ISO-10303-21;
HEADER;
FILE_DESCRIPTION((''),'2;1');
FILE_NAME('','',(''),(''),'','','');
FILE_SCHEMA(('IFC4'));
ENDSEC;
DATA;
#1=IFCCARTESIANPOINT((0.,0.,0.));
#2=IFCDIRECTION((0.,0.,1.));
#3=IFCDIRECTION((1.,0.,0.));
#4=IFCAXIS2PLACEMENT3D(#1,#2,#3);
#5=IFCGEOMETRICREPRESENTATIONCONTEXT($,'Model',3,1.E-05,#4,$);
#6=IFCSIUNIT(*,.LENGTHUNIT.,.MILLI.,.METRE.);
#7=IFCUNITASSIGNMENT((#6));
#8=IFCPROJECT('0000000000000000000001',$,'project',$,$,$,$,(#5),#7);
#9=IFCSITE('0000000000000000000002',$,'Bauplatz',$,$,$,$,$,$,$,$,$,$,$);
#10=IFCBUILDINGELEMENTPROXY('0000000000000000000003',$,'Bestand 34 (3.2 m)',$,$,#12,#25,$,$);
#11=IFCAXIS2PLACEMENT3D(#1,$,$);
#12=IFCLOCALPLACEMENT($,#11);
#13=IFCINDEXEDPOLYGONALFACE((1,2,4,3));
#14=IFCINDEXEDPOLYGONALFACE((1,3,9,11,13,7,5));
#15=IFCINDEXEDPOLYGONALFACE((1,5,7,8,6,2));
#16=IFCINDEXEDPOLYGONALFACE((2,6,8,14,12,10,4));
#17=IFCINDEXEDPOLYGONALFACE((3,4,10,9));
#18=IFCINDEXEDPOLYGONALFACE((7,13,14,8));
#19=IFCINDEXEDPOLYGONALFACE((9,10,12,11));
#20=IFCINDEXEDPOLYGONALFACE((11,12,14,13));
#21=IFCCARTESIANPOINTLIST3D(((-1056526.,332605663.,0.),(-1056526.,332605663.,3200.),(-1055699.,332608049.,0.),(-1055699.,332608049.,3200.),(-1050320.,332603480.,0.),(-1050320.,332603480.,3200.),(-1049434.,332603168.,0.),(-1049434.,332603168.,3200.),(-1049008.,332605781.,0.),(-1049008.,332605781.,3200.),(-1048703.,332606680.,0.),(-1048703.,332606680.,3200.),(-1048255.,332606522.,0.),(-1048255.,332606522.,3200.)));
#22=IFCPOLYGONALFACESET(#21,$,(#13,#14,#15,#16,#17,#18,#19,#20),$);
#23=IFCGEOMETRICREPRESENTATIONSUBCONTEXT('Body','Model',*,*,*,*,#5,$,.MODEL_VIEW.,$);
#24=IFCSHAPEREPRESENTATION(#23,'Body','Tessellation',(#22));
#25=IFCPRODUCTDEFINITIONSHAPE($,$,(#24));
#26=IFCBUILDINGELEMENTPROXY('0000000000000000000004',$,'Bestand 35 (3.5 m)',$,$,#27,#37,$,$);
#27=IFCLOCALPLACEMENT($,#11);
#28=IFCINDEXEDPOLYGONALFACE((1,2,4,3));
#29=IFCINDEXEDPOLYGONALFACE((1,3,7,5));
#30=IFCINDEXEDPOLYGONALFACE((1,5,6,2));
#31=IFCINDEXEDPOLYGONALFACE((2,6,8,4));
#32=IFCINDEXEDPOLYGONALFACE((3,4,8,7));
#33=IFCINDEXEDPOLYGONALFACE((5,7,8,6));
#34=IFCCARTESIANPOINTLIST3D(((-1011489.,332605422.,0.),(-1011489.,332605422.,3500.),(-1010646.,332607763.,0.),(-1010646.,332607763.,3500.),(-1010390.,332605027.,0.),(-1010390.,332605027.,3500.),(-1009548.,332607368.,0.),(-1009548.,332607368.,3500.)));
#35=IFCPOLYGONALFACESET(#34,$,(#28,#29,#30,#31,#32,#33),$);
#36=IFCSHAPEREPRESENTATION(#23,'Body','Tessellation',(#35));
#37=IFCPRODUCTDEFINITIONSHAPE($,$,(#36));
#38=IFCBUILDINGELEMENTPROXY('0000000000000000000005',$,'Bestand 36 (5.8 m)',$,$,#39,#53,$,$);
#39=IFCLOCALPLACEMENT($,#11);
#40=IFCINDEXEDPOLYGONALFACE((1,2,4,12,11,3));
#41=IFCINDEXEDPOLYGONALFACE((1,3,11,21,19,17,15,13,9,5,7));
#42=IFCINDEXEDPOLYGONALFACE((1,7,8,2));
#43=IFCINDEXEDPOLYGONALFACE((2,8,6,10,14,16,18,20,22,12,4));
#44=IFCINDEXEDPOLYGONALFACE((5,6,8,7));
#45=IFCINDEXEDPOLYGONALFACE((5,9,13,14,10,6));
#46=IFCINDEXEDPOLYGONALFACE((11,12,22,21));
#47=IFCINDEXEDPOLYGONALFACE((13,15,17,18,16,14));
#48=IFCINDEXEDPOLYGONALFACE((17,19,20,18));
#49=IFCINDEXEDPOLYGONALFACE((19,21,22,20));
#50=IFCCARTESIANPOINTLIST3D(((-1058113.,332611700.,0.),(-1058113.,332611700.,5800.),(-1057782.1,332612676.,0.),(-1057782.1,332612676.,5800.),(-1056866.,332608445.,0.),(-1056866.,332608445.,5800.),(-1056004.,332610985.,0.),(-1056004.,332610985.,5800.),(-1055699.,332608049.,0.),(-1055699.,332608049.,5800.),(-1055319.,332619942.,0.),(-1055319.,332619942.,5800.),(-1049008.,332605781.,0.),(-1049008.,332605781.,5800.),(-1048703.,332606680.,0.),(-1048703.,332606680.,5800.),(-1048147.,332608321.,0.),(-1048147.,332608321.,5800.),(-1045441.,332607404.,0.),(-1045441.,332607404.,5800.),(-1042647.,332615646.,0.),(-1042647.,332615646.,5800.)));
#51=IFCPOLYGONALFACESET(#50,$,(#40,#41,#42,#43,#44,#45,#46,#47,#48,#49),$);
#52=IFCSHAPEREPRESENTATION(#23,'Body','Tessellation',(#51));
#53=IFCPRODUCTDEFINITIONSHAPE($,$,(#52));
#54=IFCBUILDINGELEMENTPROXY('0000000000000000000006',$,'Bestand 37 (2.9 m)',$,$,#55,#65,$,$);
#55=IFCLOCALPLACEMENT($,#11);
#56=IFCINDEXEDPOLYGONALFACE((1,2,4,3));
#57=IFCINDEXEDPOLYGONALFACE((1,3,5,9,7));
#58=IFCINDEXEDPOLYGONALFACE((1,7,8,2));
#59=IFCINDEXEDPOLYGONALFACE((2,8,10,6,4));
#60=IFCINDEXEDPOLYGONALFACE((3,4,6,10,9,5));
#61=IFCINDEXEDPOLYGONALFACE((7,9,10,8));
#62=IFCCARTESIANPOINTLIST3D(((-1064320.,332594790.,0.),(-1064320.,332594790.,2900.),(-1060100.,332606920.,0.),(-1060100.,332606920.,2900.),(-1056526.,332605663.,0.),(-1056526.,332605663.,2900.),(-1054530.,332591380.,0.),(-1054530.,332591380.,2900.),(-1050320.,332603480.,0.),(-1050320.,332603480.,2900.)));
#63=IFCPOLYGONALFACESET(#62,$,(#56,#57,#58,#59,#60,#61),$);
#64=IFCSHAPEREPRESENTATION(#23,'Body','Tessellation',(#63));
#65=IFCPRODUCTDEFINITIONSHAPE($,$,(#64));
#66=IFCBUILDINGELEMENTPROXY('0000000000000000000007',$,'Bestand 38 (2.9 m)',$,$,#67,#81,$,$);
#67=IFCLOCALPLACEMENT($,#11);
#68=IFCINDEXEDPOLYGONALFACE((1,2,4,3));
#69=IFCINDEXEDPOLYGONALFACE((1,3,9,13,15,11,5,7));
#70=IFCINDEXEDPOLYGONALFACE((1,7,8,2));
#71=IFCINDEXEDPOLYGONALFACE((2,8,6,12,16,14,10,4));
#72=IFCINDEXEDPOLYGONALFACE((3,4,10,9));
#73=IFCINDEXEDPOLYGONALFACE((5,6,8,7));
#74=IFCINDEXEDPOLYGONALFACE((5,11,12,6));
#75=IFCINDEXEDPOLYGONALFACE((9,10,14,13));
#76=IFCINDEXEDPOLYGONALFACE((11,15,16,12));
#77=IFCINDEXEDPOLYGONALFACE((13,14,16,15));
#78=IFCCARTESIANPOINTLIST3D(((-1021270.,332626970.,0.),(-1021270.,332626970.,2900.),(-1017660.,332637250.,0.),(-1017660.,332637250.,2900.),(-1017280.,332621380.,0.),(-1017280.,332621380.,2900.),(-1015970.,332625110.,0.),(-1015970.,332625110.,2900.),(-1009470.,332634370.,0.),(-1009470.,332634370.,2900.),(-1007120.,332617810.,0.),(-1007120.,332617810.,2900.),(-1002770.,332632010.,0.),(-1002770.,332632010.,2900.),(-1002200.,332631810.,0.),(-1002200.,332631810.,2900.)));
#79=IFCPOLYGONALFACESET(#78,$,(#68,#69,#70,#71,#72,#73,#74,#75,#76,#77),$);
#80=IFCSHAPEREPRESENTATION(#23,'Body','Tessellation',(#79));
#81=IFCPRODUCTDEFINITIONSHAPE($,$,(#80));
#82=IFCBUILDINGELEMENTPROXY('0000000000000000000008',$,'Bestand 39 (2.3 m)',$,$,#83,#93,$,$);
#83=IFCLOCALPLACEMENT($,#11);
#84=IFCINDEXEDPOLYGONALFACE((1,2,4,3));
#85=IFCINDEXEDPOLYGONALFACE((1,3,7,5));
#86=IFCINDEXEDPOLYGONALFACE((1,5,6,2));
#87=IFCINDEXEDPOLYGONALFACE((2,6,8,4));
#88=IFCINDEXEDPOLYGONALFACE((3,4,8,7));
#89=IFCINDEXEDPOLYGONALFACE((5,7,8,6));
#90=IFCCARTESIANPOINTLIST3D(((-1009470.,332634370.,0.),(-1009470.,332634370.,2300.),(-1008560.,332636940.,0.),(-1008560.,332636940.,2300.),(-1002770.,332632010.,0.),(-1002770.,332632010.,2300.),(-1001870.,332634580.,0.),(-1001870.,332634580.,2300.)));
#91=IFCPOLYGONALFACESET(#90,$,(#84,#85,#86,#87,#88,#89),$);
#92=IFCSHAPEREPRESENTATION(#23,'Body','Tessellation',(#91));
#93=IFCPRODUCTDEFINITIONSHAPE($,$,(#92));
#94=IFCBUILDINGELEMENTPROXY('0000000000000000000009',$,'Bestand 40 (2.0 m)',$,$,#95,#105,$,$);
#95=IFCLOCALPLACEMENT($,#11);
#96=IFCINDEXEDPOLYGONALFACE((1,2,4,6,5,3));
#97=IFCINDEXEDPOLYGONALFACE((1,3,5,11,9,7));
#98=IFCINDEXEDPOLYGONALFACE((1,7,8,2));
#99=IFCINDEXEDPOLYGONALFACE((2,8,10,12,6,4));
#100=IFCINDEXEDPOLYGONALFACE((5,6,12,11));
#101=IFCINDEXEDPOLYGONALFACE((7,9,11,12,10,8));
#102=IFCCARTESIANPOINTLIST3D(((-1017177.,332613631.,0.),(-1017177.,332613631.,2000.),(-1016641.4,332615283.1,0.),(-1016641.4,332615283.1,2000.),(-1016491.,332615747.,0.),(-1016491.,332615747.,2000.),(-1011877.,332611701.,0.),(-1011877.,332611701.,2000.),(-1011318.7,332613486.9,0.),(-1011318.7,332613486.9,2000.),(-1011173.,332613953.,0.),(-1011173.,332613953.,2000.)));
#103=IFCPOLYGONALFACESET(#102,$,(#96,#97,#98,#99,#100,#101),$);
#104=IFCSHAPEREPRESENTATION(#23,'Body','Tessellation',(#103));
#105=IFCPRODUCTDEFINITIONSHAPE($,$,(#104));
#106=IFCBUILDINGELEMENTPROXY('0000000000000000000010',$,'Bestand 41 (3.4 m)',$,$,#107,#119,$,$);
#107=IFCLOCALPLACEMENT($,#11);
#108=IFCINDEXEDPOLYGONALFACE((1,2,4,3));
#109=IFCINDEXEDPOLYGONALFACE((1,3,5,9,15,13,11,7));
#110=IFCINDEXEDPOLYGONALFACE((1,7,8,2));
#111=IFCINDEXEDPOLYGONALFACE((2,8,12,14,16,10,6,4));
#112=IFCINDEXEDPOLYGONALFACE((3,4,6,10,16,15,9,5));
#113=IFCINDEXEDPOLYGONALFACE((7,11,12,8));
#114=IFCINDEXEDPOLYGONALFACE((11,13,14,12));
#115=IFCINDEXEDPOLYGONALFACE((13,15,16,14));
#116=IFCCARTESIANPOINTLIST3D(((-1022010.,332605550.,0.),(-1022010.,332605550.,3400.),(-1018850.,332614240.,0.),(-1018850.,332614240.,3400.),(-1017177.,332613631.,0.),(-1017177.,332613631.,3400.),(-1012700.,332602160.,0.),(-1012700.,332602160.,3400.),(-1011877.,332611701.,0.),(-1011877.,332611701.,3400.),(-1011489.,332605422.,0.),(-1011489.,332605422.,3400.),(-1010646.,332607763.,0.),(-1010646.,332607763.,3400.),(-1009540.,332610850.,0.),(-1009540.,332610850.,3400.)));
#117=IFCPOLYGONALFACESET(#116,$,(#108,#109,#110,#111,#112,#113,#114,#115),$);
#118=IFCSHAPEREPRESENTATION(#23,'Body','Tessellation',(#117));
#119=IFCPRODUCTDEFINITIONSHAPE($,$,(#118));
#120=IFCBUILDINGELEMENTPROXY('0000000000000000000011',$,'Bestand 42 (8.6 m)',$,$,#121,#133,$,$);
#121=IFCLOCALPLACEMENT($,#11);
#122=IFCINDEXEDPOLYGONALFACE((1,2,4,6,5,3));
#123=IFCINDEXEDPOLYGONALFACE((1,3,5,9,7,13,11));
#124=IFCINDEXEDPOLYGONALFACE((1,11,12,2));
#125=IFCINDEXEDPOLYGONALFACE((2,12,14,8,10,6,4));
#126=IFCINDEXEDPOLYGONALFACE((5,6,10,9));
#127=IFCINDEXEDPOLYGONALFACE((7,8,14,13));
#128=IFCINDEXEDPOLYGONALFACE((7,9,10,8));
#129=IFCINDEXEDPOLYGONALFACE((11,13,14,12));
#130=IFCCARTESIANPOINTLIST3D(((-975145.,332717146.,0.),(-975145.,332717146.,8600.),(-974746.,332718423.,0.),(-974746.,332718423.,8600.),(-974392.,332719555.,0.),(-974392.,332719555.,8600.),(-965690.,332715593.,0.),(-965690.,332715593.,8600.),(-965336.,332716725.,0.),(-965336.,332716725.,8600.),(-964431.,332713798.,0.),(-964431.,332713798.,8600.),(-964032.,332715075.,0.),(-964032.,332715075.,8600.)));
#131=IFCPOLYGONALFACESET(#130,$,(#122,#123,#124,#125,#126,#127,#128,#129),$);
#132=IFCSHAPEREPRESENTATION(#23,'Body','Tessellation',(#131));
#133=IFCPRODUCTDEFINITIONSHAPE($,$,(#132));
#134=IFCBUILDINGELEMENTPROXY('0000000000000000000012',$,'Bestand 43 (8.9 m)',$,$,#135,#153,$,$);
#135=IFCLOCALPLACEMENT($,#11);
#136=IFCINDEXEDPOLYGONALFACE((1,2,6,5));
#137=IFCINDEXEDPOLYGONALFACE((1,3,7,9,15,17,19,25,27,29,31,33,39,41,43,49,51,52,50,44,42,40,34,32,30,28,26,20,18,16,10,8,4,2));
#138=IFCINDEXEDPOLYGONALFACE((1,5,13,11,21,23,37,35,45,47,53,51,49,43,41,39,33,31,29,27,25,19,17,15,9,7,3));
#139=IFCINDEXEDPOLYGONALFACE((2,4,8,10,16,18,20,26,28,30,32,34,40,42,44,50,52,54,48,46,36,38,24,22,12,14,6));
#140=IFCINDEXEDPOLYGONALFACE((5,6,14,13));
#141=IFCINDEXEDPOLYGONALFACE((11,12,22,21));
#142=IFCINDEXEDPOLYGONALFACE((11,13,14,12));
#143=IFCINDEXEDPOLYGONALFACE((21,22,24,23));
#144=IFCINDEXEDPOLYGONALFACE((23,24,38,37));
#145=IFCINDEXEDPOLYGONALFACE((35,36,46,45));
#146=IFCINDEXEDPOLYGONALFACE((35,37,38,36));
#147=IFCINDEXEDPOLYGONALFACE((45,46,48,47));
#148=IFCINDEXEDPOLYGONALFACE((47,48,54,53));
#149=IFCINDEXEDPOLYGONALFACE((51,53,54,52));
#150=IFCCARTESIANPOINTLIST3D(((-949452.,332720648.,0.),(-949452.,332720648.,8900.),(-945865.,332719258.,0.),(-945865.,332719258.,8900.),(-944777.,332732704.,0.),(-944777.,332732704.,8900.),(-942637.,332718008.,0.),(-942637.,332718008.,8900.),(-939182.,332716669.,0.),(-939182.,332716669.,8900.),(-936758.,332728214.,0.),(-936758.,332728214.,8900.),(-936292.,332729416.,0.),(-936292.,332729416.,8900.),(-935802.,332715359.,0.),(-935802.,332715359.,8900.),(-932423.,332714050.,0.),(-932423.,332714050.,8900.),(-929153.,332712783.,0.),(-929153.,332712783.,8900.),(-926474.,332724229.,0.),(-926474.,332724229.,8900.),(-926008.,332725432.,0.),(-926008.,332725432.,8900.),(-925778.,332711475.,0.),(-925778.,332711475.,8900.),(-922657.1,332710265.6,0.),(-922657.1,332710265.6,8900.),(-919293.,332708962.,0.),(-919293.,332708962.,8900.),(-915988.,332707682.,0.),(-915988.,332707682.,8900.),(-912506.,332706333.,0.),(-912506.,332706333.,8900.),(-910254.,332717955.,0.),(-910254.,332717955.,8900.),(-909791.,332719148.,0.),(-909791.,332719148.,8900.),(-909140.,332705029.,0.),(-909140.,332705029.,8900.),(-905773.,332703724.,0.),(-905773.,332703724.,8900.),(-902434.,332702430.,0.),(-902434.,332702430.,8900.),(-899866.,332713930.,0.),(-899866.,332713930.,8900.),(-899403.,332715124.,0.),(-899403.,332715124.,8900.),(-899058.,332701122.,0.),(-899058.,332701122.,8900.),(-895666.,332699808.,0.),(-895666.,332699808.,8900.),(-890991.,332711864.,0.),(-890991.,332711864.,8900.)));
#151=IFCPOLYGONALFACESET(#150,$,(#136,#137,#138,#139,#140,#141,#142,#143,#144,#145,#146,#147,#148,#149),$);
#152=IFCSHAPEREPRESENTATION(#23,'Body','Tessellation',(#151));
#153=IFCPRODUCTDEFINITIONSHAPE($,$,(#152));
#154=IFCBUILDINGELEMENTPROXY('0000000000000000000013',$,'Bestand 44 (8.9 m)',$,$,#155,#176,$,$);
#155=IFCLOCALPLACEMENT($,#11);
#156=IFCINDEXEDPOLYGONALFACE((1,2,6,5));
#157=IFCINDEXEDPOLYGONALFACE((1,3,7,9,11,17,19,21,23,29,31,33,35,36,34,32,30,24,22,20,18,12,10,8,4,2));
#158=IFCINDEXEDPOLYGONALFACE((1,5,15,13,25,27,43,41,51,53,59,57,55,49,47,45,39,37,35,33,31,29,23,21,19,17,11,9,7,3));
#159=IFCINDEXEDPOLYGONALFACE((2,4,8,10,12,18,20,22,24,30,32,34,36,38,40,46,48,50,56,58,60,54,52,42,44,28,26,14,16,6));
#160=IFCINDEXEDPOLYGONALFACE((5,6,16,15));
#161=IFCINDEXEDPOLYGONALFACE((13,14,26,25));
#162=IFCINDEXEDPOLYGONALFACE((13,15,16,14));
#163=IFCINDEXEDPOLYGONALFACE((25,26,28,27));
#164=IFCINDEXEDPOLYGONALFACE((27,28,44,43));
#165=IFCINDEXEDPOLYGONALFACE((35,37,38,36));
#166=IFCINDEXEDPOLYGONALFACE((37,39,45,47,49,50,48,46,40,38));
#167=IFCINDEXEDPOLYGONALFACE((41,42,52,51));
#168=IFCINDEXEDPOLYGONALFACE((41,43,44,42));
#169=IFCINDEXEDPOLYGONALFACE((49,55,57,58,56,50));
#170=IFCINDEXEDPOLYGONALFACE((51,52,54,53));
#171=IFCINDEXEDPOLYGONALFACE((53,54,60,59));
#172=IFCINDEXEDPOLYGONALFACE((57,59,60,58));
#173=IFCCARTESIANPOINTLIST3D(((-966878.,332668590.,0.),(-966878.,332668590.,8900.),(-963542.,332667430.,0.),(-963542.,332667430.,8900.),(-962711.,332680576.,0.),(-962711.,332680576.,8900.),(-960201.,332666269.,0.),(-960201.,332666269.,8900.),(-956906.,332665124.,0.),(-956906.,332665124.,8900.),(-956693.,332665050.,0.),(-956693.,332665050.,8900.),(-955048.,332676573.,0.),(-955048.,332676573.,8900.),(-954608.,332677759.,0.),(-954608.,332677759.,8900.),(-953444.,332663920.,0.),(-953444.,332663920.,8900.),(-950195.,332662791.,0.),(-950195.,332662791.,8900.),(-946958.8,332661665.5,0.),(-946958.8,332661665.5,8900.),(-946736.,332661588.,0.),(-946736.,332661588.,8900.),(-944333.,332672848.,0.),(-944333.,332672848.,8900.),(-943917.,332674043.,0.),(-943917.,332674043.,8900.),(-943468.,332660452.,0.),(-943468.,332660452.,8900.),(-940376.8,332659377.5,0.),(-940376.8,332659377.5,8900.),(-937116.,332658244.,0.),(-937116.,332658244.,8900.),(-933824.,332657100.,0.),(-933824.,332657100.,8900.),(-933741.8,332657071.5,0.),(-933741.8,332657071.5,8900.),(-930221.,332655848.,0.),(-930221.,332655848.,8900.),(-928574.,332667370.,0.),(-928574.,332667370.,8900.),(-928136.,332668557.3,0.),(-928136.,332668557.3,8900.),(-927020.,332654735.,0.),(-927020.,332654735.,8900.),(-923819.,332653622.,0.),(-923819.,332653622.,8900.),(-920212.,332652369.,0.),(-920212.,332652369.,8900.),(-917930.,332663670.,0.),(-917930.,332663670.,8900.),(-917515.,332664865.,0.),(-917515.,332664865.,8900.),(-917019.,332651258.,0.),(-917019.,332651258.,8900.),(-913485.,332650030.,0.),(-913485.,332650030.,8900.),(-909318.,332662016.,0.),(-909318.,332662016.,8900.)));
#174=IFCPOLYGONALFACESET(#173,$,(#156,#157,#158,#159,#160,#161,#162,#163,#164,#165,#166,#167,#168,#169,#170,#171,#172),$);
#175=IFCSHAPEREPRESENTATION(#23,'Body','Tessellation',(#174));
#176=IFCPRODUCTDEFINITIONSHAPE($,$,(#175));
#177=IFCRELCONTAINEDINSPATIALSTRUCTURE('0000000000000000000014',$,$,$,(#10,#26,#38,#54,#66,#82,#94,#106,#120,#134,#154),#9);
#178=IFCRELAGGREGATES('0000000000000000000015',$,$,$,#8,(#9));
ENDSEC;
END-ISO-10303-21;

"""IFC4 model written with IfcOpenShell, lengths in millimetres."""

from ifc_helpers import new_model, si_unit, origin_with_axes, place, context, subcontext, project, spatial, indexed_curve, outline, extrude, element, save


model = new_model("IFC4")

# Units and contexts
model_context = context("Model", 3, precision=1e-05, world=origin_with_axes())
body_context = subcontext(model_context, "Body", "Model", "MODEL_VIEW")
ifc_project = project(units=[si_unit("LENGTHUNIT", "METRE", prefix="MILLI")], contexts=[model_context])

# Site
site = spatial("IfcSite", under=ifc_project, Name="Bauplatz")

# Building element proxies
proxy_1_placement = place(None, origin_with_axes())
element("IfcBuildingElementProxy", 1, at=proxy_1_placement, inside=site, Name="Bestand 34 (3.2 m)", context=body_context, shape_type="SweptSolid", body=[
    extrude(outline(indexed_curve([(-1049008.0, 332605781.0), (-1055699.0, 332608049.0), (-1056526.0, 332605663.0), (-1050320.0, 332603480.0), (-1049434.0, 332603168.0), (-1048255.0, 332606522.0), (-1048703.0, 332606680.0)])), None, (0.0, 0.0, 1.0), 3200.0),
])
proxy_2_placement = place(None, origin_with_axes())
element("IfcBuildingElementProxy", 2, at=proxy_2_placement, inside=site, Name="Bestand 35 (3.5 m)", context=body_context, shape_type="SweptSolid", body=[
    extrude(outline(indexed_curve([(-1009548.0, 332607368.0), (-1010646.0, 332607763.0), (-1011489.0, 332605422.0), (-1010390.0, 332605027.0)])), None, (0.0, 0.0, 1.0), 3500.0),
])
proxy_3_placement = place(None, origin_with_axes())
element("IfcBuildingElementProxy", 3, at=proxy_3_placement, inside=site, Name="Bestand 36 (5.8 m)", context=body_context, shape_type="SweptSolid", body=[
    extrude(outline(indexed_curve([(-1042647.0, 332615646.0), (-1055319.0, 332619942.0), (-1057782.1, 332612676.0), (-1058113.0, 332611700.0), (-1056004.0, 332610985.0), (-1056866.0, 332608445.0), (-1055699.0, 332608049.0), (-1049008.0, 332605781.0), (-1048703.0, 332606680.0), (-1048147.0, 332608321.0), (-1045441.0, 332607404.0)])), None, (0.0, 0.0, 1.0), 5800.0),
])
proxy_4_placement = place(None, origin_with_axes())
element("IfcBuildingElementProxy", 4, at=proxy_4_placement, inside=site, Name="Bestand 37 (2.9 m)", context=body_context, shape_type="SweptSolid", body=[
    extrude(outline(indexed_curve([(-1056526.0, 332605663.0), (-1060100.0, 332606920.0), (-1064320.0, 332594790.0), (-1054530.0, 332591380.0), (-1050320.0, 332603480.0)])), None, (0.0, 0.0, 1.0), 2900.0),
])
proxy_5_placement = place(None, origin_with_axes())
element("IfcBuildingElementProxy", 5, at=proxy_5_placement, inside=site, Name="Bestand 38 (2.9 m)", context=body_context, shape_type="SweptSolid", body=[
    extrude(outline(indexed_curve([(-1009470.0, 332634370.0), (-1017660.0, 332637250.0), (-1021270.0, 332626970.0), (-1015970.0, 332625110.0), (-1017280.0, 332621380.0), (-1007120.0, 332617810.0), (-1002200.0, 332631810.0), (-1002770.0, 332632010.0)])), None, (0.0, 0.0, 1.0), 2900.0),
])
proxy_6_placement = place(None, origin_with_axes())
element("IfcBuildingElementProxy", 6, at=proxy_6_placement, inside=site, Name="Bestand 39 (2.3 m)", context=body_context, shape_type="SweptSolid", body=[
    extrude(outline(indexed_curve([(-1001870.0, 332634580.0), (-1008560.0, 332636940.0), (-1009470.0, 332634370.0), (-1002770.0, 332632010.0)])), None, (0.0, 0.0, 1.0), 2300.0),
])
proxy_7_placement = place(None, origin_with_axes())
element("IfcBuildingElementProxy", 7, at=proxy_7_placement, inside=site, Name="Bestand 40 (2.0 m)", context=body_context, shape_type="SweptSolid", body=[
    extrude(outline(indexed_curve([(-1011173.0, 332613953.0), (-1016491.0, 332615747.0), (-1016641.4, 332615283.1), (-1017177.0, 332613631.0), (-1011877.0, 332611701.0), (-1011318.7, 332613486.9)])), None, (0.0, 0.0, 1.0), 2000.0),
])
proxy_8_placement = place(None, origin_with_axes())
element("IfcBuildingElementProxy", 8, at=proxy_8_placement, inside=site, Name="Bestand 41 (3.4 m)", context=body_context, shape_type="SweptSolid", body=[
    extrude(outline(indexed_curve([(-1017177.0, 332613631.0), (-1018850.0, 332614240.0), (-1022010.0, 332605550.0), (-1012700.0, 332602160.0), (-1011489.0, 332605422.0), (-1010646.0, 332607763.0), (-1009540.0, 332610850.0), (-1011877.0, 332611701.0)])), None, (0.0, 0.0, 1.0), 3400.0),
])
proxy_9_placement = place(None, origin_with_axes())
element("IfcBuildingElementProxy", 9, at=proxy_9_placement, inside=site, Name="Bestand 42 (8.6 m)", context=body_context, shape_type="SweptSolid", body=[
    extrude(outline(indexed_curve([(-965336.0, 332716725.0), (-974392.0, 332719555.0), (-974746.0, 332718423.0), (-975145.0, 332717146.0), (-964431.0, 332713798.0), (-964032.0, 332715075.0), (-965690.0, 332715593.0)])), None, (0.0, 0.0, 1.0), 8600.0),
])
proxy_10_placement = place(None, origin_with_axes())
element("IfcBuildingElementProxy", 10, at=proxy_10_placement, inside=site, Name="Bestand 43 (8.9 m)", context=body_context, shape_type="SweptSolid", body=[
    extrude(outline(indexed_curve([(-936292.0, 332729416.0), (-944777.0, 332732704.0), (-949452.0, 332720648.0), (-945865.0, 332719258.0), (-942637.0, 332718008.0), (-939182.0, 332716669.0), (-935802.0, 332715359.0), (-932423.0, 332714050.0), (-929153.0, 332712783.0), (-925778.0, 332711475.0), (-922657.1, 332710265.6), (-919293.0, 332708962.0), (-915988.0, 332707682.0), (-912506.0, 332706333.0), (-909140.0, 332705029.0), (-905773.0, 332703724.0), (-902434.0, 332702430.0), (-899058.0, 332701122.0), (-895666.0, 332699808.0), (-890991.0, 332711864.0), (-899403.0, 332715124.0), (-899866.0, 332713930.0), (-910254.0, 332717955.0), (-909791.0, 332719148.0), (-926008.0, 332725432.0), (-926474.0, 332724229.0), (-936758.0, 332728214.0)])), None, (0.0, 0.0, 1.0), 8900.0),
])
proxy_11_placement = place(None, origin_with_axes())
element("IfcBuildingElementProxy", 11, at=proxy_11_placement, inside=site, Name="Bestand 44 (8.9 m)", context=body_context, shape_type="SweptSolid", body=[
    extrude(outline(indexed_curve([(-954608.0, 332677759.0), (-962711.0, 332680576.0), (-966878.0, 332668590.0), (-963542.0, 332667430.0), (-960201.0, 332666269.0), (-956906.0, 332665124.0), (-956693.0, 332665050.0), (-953444.0, 332663920.0), (-950195.0, 332662791.0), (-946958.8, 332661665.5), (-946736.0, 332661588.0), (-943468.0, 332660452.0), (-940376.8, 332659377.5), (-937116.0, 332658244.0), (-933824.0, 332657100.0), (-933741.8, 332657071.5), (-930221.0, 332655848.0), (-927020.0, 332654735.0), (-923819.0, 332653622.0), (-920212.0, 332652369.0), (-917019.0, 332651258.0), (-913485.0, 332650030.0), (-909318.0, 332662016.0), (-917515.0, 332664865.0), (-917930.0, 332663670.0), (-928574.0, 332667370.0), (-928136.0, 332668557.3), (-943917.0, 332674043.0), (-944333.0, 332672848.0), (-955048.0, 332676573.0)])), None, (0.0, 0.0, 1.0), 8900.0),
])

save(model, "model.ifc")
